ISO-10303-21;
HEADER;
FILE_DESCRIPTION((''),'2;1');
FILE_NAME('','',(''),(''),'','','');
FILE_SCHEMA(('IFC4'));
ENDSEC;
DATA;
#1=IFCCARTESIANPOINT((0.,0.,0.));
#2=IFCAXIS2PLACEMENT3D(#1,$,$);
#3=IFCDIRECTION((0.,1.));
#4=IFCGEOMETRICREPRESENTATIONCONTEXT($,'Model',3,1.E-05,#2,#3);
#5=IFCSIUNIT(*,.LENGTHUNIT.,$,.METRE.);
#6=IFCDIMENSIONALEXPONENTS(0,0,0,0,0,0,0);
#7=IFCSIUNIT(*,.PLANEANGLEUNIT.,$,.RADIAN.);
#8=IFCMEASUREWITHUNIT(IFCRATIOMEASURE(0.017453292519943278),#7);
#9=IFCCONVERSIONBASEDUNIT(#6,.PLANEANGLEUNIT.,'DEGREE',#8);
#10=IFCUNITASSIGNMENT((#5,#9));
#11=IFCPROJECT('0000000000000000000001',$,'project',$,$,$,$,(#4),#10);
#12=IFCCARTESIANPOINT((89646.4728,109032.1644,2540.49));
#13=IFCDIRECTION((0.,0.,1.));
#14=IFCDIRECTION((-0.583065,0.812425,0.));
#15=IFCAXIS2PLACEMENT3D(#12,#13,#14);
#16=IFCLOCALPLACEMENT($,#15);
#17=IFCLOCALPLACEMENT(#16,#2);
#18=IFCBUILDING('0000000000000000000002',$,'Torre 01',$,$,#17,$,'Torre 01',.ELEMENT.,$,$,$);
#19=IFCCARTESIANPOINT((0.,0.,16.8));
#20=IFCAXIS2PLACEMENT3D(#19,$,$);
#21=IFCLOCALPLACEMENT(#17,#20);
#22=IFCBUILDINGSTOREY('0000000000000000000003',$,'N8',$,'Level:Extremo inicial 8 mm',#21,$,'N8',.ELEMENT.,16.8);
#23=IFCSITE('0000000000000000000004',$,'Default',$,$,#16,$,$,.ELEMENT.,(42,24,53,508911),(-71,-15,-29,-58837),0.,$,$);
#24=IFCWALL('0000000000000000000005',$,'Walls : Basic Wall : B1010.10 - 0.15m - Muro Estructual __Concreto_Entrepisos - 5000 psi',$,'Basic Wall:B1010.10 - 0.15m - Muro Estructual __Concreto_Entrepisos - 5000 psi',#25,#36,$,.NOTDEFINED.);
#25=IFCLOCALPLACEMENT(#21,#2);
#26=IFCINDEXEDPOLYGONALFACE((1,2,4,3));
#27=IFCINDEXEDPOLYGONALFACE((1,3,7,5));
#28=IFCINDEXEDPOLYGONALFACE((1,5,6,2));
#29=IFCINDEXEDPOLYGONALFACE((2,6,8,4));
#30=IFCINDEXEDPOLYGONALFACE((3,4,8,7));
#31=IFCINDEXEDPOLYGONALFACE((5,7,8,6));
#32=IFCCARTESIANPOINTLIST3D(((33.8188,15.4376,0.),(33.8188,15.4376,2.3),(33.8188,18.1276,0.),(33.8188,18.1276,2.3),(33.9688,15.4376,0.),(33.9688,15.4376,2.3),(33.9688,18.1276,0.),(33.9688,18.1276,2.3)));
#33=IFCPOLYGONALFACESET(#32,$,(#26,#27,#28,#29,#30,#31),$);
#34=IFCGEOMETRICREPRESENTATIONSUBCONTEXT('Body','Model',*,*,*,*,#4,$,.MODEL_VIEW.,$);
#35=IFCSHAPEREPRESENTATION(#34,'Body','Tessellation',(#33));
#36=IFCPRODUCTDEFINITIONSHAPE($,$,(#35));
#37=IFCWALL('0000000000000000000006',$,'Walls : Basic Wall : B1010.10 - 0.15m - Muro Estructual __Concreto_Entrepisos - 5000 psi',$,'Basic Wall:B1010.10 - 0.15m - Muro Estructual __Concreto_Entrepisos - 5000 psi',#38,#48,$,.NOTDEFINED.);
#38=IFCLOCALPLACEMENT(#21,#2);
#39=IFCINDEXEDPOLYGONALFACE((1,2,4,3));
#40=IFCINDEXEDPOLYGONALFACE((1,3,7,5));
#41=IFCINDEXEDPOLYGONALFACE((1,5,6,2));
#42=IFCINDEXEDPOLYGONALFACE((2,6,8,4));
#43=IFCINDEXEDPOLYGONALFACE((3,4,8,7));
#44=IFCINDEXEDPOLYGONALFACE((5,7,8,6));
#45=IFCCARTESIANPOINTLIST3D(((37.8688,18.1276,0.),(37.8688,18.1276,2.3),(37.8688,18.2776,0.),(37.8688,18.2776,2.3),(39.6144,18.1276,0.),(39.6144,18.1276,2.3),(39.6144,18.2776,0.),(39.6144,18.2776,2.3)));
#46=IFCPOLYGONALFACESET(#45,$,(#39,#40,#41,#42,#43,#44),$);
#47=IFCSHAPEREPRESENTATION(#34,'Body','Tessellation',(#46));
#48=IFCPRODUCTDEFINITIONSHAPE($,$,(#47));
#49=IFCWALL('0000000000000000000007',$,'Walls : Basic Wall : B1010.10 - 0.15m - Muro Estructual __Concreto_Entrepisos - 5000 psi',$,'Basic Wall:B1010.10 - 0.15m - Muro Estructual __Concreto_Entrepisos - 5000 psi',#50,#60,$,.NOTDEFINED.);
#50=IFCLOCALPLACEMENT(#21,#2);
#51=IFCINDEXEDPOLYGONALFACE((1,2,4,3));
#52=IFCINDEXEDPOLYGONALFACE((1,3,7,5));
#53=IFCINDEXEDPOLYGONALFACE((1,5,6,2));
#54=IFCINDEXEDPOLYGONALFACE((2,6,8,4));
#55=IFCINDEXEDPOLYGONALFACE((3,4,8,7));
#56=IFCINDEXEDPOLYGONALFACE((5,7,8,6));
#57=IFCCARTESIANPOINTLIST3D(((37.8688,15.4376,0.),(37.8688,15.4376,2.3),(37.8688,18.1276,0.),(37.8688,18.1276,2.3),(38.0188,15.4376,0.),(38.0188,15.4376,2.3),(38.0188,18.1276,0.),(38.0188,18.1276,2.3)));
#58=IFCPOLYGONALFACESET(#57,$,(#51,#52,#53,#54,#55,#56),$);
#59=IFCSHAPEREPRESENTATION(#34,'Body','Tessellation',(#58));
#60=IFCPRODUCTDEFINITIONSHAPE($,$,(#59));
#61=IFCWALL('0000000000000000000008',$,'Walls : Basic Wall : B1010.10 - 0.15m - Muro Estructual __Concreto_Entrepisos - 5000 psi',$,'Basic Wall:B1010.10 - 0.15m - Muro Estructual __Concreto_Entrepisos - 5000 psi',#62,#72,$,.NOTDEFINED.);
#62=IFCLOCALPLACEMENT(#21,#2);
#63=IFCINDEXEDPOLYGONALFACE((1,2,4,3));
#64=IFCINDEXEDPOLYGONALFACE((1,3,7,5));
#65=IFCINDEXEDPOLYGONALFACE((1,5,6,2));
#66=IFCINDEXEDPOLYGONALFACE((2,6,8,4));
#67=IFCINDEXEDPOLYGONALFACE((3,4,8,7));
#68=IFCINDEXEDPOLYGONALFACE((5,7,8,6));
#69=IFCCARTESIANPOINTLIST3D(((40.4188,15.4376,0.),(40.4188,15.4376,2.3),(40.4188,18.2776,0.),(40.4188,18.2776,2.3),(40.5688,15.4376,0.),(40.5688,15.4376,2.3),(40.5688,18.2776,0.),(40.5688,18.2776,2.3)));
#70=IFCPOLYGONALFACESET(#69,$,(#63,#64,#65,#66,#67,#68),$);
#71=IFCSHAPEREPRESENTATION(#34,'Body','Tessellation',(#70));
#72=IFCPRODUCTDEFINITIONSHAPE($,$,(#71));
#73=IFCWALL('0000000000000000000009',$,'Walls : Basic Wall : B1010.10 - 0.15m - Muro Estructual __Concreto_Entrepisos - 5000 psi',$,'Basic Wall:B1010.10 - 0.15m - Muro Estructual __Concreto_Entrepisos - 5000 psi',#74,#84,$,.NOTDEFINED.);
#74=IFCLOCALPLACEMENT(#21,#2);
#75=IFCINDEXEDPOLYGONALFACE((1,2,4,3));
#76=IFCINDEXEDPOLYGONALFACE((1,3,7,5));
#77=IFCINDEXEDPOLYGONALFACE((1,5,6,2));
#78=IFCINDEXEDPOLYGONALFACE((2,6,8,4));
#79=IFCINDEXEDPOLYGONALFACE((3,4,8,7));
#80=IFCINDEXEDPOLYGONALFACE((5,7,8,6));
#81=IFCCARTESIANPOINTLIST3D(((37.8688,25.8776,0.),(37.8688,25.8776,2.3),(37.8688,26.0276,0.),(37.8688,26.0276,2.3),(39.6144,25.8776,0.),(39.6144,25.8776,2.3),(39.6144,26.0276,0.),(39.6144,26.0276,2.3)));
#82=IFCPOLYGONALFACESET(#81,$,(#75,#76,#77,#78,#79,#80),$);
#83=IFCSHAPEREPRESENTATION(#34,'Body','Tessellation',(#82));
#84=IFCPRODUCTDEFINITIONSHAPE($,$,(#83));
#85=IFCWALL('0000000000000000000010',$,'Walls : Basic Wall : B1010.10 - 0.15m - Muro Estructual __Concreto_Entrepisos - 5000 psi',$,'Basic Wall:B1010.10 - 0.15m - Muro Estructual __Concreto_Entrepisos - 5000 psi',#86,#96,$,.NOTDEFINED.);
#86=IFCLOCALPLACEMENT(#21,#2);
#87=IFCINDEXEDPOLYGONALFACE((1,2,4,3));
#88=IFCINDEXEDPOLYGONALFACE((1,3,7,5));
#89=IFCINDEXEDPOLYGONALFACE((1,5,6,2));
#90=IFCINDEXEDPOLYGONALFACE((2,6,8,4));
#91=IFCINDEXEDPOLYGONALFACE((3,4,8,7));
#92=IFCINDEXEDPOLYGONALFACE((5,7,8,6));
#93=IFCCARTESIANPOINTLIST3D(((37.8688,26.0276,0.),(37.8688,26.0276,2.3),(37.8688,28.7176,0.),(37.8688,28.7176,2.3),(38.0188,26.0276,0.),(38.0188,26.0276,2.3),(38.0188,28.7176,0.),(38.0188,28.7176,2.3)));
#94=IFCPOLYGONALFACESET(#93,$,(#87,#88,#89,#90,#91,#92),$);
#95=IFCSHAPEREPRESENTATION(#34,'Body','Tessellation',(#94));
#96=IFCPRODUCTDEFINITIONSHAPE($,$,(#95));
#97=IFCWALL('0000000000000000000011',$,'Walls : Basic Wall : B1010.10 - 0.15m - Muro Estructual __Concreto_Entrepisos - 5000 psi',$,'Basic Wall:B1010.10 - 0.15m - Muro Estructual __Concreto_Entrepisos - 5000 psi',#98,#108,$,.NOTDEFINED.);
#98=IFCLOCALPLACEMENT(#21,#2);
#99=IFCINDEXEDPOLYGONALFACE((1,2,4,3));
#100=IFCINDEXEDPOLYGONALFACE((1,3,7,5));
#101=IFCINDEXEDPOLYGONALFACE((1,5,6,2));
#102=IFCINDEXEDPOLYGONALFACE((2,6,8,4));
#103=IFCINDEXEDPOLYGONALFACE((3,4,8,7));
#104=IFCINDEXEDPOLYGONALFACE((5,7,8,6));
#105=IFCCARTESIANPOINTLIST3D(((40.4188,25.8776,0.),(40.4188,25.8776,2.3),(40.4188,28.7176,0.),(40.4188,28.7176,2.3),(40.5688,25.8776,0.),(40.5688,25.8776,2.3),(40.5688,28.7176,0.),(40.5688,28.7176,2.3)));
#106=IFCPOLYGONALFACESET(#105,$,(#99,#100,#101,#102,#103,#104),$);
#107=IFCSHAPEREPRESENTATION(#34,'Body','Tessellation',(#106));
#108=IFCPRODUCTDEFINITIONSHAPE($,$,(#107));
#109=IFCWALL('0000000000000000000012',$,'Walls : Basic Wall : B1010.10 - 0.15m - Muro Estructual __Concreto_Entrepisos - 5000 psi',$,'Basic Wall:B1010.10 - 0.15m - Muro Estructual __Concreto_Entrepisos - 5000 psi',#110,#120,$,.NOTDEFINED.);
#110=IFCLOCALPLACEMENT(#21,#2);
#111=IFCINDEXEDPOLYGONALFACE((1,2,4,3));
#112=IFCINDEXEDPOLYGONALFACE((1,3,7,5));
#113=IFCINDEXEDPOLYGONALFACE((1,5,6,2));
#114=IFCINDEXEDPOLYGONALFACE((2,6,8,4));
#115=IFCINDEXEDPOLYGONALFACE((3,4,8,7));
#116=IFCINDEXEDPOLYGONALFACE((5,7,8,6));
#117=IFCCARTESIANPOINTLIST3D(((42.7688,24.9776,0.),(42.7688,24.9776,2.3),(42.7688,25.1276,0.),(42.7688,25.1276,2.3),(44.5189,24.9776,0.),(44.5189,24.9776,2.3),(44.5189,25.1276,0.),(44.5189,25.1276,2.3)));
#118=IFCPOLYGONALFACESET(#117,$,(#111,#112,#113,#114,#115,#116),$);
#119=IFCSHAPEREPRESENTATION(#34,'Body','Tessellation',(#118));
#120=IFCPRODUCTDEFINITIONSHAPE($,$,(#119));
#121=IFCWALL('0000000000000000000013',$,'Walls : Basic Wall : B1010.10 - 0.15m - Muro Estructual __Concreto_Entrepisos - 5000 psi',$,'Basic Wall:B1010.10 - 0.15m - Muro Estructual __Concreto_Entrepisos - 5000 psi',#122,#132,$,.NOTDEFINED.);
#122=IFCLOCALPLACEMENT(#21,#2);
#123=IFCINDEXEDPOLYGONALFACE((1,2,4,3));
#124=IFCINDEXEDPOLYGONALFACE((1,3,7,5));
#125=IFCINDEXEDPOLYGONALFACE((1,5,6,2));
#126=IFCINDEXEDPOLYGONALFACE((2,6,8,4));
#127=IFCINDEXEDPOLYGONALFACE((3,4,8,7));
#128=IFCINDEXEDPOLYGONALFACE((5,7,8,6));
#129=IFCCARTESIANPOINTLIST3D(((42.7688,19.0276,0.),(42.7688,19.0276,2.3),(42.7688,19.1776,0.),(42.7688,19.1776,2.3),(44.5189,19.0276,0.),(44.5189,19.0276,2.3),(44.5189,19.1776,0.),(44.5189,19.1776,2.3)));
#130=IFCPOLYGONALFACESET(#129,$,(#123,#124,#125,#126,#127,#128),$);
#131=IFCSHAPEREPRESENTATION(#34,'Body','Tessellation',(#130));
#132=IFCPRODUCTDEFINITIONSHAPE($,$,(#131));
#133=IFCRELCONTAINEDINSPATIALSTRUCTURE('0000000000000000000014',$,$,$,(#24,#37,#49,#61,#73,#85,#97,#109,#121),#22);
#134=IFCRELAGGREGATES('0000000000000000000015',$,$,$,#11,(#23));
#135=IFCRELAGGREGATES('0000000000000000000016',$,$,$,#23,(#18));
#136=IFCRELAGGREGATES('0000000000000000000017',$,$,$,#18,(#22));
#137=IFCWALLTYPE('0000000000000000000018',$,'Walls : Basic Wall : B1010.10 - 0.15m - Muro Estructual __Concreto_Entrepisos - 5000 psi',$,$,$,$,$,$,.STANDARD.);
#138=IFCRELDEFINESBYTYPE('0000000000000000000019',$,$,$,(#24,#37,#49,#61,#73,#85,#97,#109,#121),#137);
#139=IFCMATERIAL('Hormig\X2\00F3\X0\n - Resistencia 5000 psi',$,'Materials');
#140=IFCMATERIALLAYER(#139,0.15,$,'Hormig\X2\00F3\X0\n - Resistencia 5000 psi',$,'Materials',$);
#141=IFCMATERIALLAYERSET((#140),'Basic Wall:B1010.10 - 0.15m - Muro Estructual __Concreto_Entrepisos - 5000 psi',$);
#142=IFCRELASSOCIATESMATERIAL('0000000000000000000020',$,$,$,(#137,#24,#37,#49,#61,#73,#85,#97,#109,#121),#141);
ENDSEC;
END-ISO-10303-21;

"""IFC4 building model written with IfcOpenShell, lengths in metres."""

from ifc_helpers import new_model, entity, si_unit, converted_unit, direction, frame, frame_2d, origin, place, context, subcontext, project, spatial, rectangle, extrude, material, layer, layer_set, layer_usage, type_object, element, save


model = new_model("IFC4")

# Units and contexts
model_context = context("Model", 3, precision=1e-05, world=origin(), true_north=direction((0.0, 1.0)))
body_context = subcontext(model_context, "Body", "Model", "MODEL_VIEW")
ifc_project = project(units=[si_unit("LENGTHUNIT", "METRE"), converted_unit("PLANEANGLEUNIT", "DEGREE", entity("IfcRatioMeasure", 0.017453292519943278), si_unit("PLANEANGLEUNIT", "RADIAN"), dimensions=[0, 0, 0, 0, 0, 0, 0])], contexts=[model_context])

# Site, building, storey
site_placement = place(None, frame((89646.4728, 109032.1644, 2540.49), z_axis=(0.0, 0.0, 1.0), x_axis=(-0.583065, 0.812425, 0.0)))
site = spatial("IfcSite", under=ifc_project, at=site_placement, Name="Default", CompositionType="ELEMENT", RefLatitude=(42, 24, 53, 508911), RefLongitude=(-71, -15, -29, -58837), RefElevation=0.0)
building_placement = place(site_placement, origin())
building = spatial("IfcBuilding", under=site, at=building_placement, Name="Torre 01", LongName="Torre 01", CompositionType="ELEMENT")
storey_placement = place(building_placement, frame((0.0, 0.0, 16.8)))
storey = spatial("IfcBuildingStorey", under=building, at=storey_placement, Name="N8", ObjectType="Level:Extremo inicial 8 mm", LongName="N8", CompositionType="ELEMENT", Elevation=16.8)

# Walls
ifc_material = material(Name="Hormigón - Resistencia 5000 psi", Category="Materials")
ifc_layer_1 = layer(ifc_material, 0.15, Name="Hormigón - Resistencia 5000 psi", Category="Materials")
ifc_layer_set_1 = layer_set([ifc_layer_1], Name="Basic Wall:B1010.10 - 0.15m - Muro Estructual __Concreto_Entrepisos - 5000 psi")
wall_type_1 = type_object("IfcWallType", Name="Walls : Basic Wall : B1010.10 - 0.15m - Muro Estructual __Concreto_Entrepisos - 5000 psi", PredefinedType="STANDARD", material=ifc_layer_set_1)
ifc_layer_usage_1 = layer_usage(ifc_layer_set_1, "AXIS2", "NEGATIVE", 0.075)
wall_1_placement = place(storey_placement, frame((33.8938, 18.1276, 0.0), z_axis=(0.0, 0.0, 1.0), x_axis=(0.0, -1.0, 0.0)))
element("IfcWall", 1, at=wall_1_placement, inside=storey, type_object=wall_type_1, material=ifc_layer_usage_1, Name="Walls : Basic Wall : B1010.10 - 0.15m - Muro Estructual __Concreto_Entrepisos - 5000 psi", ObjectType="Basic Wall:B1010.10 - 0.15m - Muro Estructual __Concreto_Entrepisos - 5000 psi", PredefinedType="NOTDEFINED", context=body_context, shape_type="SweptSolid", body=[
    extrude(rectangle(XDim=2.69, YDim=0.15, at=frame_2d((1.345, 0.0), x_axis=(-1.0, 0.0))), origin(), (0.0, 0.0, 1.0), 2.3),
])
ifc_layer_usage_2 = layer_usage(ifc_layer_set_1, "AXIS2", "NEGATIVE", 0.075)
wall_2_placement = place(storey_placement, frame((39.6144, 18.2026, 0.0), z_axis=(0.0, 0.0, 1.0), x_axis=(-1.0, 0.0, 0.0)))
element("IfcWall", 2, at=wall_2_placement, inside=storey, type_object=wall_type_1, material=ifc_layer_usage_2, Name="Walls : Basic Wall : B1010.10 - 0.15m - Muro Estructual __Concreto_Entrepisos - 5000 psi", ObjectType="Basic Wall:B1010.10 - 0.15m - Muro Estructual __Concreto_Entrepisos - 5000 psi", PredefinedType="NOTDEFINED", context=body_context, shape_type="SweptSolid", body=[
    extrude(rectangle(XDim=1.7455, YDim=0.15, at=frame_2d((0.8728, 0.0), x_axis=(-1.0, 0.0))), origin(), (0.0, 0.0, 1.0), 2.3),
])
ifc_layer_usage_3 = layer_usage(ifc_layer_set_1, "AXIS2", "NEGATIVE", 0.075)
wall_3_placement = place(storey_placement, frame((37.9438, 18.1276, 0.0), z_axis=(0.0, 0.0, 1.0), x_axis=(0.0, -1.0, 0.0)))
element("IfcWall", 3, at=wall_3_placement, inside=storey, type_object=wall_type_1, material=ifc_layer_usage_3, Name="Walls : Basic Wall : B1010.10 - 0.15m - Muro Estructual __Concreto_Entrepisos - 5000 psi", ObjectType="Basic Wall:B1010.10 - 0.15m - Muro Estructual __Concreto_Entrepisos - 5000 psi", PredefinedType="NOTDEFINED", context=body_context, shape_type="SweptSolid", body=[
    extrude(rectangle(XDim=2.69, YDim=0.15, at=frame_2d((1.345, 0.0), x_axis=(-1.0, 0.0))), origin(), (0.0, 0.0, 1.0), 2.3),
])
ifc_layer_usage_4 = layer_usage(ifc_layer_set_1, "AXIS2", "NEGATIVE", 0.075)
wall_4_placement = place(storey_placement, frame((40.4938, 18.2776, 0.0), z_axis=(0.0, 0.0, 1.0), x_axis=(0.0, -1.0, 0.0)))
element("IfcWall", 4, at=wall_4_placement, inside=storey, type_object=wall_type_1, material=ifc_layer_usage_4, Name="Walls : Basic Wall : B1010.10 - 0.15m - Muro Estructual __Concreto_Entrepisos - 5000 psi", ObjectType="Basic Wall:B1010.10 - 0.15m - Muro Estructual __Concreto_Entrepisos - 5000 psi", PredefinedType="NOTDEFINED", context=body_context, shape_type="SweptSolid", body=[
    extrude(rectangle(XDim=2.84, YDim=0.15, at=frame_2d((1.42, 0.0), x_axis=(-1.0, 0.0))), origin(), (0.0, 0.0, 1.0), 2.3),
])
ifc_layer_usage_5 = layer_usage(ifc_layer_set_1, "AXIS2", "POSITIVE", -0.075)
wall_5_placement = place(storey_placement, frame((39.6144, 25.9526, 0.0), z_axis=(0.0, 0.0, 1.0), x_axis=(-1.0, 0.0, 0.0)))
element("IfcWall", 5, at=wall_5_placement, inside=storey, type_object=wall_type_1, material=ifc_layer_usage_5, Name="Walls : Basic Wall : B1010.10 - 0.15m - Muro Estructual __Concreto_Entrepisos - 5000 psi", ObjectType="Basic Wall:B1010.10 - 0.15m - Muro Estructual __Concreto_Entrepisos - 5000 psi", PredefinedType="NOTDEFINED", context=body_context, shape_type="SweptSolid", body=[
    extrude(rectangle(XDim=1.7455, YDim=0.15, at=frame_2d((0.8728, 0.0), x_axis=(-1.0, 0.0))), origin(), (0.0, 0.0, 1.0), 2.3),
])
ifc_layer_usage_6 = layer_usage(ifc_layer_set_1, "AXIS2", "POSITIVE", -0.075)
wall_6_placement = place(storey_placement, frame((37.9438, 26.0276, 0.0), z_axis=(0.0, 0.0, 1.0), x_axis=(0.0, 1.0, 0.0)))
element("IfcWall", 6, at=wall_6_placement, inside=storey, type_object=wall_type_1, material=ifc_layer_usage_6, Name="Walls : Basic Wall : B1010.10 - 0.15m - Muro Estructual __Concreto_Entrepisos - 5000 psi", ObjectType="Basic Wall:B1010.10 - 0.15m - Muro Estructual __Concreto_Entrepisos - 5000 psi", PredefinedType="NOTDEFINED", context=body_context, shape_type="SweptSolid", body=[
    extrude(rectangle(XDim=2.69, YDim=0.15, at=frame_2d((1.345, 0.0), x_axis=(-1.0, 0.0))), origin(), (0.0, 0.0, 1.0), 2.3),
])
ifc_layer_usage_7 = layer_usage(ifc_layer_set_1, "AXIS2", "POSITIVE", -0.075)
wall_7_placement = place(storey_placement, frame((40.4938, 25.8776, 0.0), z_axis=(0.0, 0.0, 1.0), x_axis=(0.0, 1.0, 0.0)))
element("IfcWall", 7, at=wall_7_placement, inside=storey, type_object=wall_type_1, material=ifc_layer_usage_7, Name="Walls : Basic Wall : B1010.10 - 0.15m - Muro Estructual __Concreto_Entrepisos - 5000 psi", ObjectType="Basic Wall:B1010.10 - 0.15m - Muro Estructual __Concreto_Entrepisos - 5000 psi", PredefinedType="NOTDEFINED", context=body_context, shape_type="SweptSolid", body=[
    extrude(rectangle(XDim=2.84, YDim=0.15, at=frame_2d((1.42, 0.0), x_axis=(-1.0, 0.0))), origin(), (0.0, 0.0, 1.0), 2.3),
])
ifc_layer_usage_8 = layer_usage(ifc_layer_set_1, "AXIS2", "NEGATIVE", 0.075)
wall_8_placement = place(storey_placement, frame((42.7688, 25.0526, 0.0)))
element("IfcWall", 8, at=wall_8_placement, inside=storey, type_object=wall_type_1, material=ifc_layer_usage_8, Name="Walls : Basic Wall : B1010.10 - 0.15m - Muro Estructual __Concreto_Entrepisos - 5000 psi", ObjectType="Basic Wall:B1010.10 - 0.15m - Muro Estructual __Concreto_Entrepisos - 5000 psi", PredefinedType="NOTDEFINED", context=body_context, shape_type="SweptSolid", body=[
    extrude(rectangle(XDim=1.75, YDim=0.15, at=frame_2d((0.875, 0.0), x_axis=(-1.0, 0.0))), origin(), (0.0, 0.0, 1.0), 2.3),
])
ifc_layer_usage_9 = layer_usage(ifc_layer_set_1, "AXIS2", "POSITIVE", -0.075)
wall_9_placement = place(storey_placement, frame((42.7688, 19.1026, 0.0)))
element("IfcWall", 9, at=wall_9_placement, inside=storey, type_object=wall_type_1, material=ifc_layer_usage_9, Name="Walls : Basic Wall : B1010.10 - 0.15m - Muro Estructual __Concreto_Entrepisos - 5000 psi", ObjectType="Basic Wall:B1010.10 - 0.15m - Muro Estructual __Concreto_Entrepisos - 5000 psi", PredefinedType="NOTDEFINED", context=body_context, shape_type="SweptSolid", body=[
    extrude(rectangle(XDim=1.75, YDim=0.15, at=frame_2d((0.875, 0.0), x_axis=(-1.0, 0.0))), origin(), (0.0, 0.0, 1.0), 2.3),
])

save(model, "model.ifc")
